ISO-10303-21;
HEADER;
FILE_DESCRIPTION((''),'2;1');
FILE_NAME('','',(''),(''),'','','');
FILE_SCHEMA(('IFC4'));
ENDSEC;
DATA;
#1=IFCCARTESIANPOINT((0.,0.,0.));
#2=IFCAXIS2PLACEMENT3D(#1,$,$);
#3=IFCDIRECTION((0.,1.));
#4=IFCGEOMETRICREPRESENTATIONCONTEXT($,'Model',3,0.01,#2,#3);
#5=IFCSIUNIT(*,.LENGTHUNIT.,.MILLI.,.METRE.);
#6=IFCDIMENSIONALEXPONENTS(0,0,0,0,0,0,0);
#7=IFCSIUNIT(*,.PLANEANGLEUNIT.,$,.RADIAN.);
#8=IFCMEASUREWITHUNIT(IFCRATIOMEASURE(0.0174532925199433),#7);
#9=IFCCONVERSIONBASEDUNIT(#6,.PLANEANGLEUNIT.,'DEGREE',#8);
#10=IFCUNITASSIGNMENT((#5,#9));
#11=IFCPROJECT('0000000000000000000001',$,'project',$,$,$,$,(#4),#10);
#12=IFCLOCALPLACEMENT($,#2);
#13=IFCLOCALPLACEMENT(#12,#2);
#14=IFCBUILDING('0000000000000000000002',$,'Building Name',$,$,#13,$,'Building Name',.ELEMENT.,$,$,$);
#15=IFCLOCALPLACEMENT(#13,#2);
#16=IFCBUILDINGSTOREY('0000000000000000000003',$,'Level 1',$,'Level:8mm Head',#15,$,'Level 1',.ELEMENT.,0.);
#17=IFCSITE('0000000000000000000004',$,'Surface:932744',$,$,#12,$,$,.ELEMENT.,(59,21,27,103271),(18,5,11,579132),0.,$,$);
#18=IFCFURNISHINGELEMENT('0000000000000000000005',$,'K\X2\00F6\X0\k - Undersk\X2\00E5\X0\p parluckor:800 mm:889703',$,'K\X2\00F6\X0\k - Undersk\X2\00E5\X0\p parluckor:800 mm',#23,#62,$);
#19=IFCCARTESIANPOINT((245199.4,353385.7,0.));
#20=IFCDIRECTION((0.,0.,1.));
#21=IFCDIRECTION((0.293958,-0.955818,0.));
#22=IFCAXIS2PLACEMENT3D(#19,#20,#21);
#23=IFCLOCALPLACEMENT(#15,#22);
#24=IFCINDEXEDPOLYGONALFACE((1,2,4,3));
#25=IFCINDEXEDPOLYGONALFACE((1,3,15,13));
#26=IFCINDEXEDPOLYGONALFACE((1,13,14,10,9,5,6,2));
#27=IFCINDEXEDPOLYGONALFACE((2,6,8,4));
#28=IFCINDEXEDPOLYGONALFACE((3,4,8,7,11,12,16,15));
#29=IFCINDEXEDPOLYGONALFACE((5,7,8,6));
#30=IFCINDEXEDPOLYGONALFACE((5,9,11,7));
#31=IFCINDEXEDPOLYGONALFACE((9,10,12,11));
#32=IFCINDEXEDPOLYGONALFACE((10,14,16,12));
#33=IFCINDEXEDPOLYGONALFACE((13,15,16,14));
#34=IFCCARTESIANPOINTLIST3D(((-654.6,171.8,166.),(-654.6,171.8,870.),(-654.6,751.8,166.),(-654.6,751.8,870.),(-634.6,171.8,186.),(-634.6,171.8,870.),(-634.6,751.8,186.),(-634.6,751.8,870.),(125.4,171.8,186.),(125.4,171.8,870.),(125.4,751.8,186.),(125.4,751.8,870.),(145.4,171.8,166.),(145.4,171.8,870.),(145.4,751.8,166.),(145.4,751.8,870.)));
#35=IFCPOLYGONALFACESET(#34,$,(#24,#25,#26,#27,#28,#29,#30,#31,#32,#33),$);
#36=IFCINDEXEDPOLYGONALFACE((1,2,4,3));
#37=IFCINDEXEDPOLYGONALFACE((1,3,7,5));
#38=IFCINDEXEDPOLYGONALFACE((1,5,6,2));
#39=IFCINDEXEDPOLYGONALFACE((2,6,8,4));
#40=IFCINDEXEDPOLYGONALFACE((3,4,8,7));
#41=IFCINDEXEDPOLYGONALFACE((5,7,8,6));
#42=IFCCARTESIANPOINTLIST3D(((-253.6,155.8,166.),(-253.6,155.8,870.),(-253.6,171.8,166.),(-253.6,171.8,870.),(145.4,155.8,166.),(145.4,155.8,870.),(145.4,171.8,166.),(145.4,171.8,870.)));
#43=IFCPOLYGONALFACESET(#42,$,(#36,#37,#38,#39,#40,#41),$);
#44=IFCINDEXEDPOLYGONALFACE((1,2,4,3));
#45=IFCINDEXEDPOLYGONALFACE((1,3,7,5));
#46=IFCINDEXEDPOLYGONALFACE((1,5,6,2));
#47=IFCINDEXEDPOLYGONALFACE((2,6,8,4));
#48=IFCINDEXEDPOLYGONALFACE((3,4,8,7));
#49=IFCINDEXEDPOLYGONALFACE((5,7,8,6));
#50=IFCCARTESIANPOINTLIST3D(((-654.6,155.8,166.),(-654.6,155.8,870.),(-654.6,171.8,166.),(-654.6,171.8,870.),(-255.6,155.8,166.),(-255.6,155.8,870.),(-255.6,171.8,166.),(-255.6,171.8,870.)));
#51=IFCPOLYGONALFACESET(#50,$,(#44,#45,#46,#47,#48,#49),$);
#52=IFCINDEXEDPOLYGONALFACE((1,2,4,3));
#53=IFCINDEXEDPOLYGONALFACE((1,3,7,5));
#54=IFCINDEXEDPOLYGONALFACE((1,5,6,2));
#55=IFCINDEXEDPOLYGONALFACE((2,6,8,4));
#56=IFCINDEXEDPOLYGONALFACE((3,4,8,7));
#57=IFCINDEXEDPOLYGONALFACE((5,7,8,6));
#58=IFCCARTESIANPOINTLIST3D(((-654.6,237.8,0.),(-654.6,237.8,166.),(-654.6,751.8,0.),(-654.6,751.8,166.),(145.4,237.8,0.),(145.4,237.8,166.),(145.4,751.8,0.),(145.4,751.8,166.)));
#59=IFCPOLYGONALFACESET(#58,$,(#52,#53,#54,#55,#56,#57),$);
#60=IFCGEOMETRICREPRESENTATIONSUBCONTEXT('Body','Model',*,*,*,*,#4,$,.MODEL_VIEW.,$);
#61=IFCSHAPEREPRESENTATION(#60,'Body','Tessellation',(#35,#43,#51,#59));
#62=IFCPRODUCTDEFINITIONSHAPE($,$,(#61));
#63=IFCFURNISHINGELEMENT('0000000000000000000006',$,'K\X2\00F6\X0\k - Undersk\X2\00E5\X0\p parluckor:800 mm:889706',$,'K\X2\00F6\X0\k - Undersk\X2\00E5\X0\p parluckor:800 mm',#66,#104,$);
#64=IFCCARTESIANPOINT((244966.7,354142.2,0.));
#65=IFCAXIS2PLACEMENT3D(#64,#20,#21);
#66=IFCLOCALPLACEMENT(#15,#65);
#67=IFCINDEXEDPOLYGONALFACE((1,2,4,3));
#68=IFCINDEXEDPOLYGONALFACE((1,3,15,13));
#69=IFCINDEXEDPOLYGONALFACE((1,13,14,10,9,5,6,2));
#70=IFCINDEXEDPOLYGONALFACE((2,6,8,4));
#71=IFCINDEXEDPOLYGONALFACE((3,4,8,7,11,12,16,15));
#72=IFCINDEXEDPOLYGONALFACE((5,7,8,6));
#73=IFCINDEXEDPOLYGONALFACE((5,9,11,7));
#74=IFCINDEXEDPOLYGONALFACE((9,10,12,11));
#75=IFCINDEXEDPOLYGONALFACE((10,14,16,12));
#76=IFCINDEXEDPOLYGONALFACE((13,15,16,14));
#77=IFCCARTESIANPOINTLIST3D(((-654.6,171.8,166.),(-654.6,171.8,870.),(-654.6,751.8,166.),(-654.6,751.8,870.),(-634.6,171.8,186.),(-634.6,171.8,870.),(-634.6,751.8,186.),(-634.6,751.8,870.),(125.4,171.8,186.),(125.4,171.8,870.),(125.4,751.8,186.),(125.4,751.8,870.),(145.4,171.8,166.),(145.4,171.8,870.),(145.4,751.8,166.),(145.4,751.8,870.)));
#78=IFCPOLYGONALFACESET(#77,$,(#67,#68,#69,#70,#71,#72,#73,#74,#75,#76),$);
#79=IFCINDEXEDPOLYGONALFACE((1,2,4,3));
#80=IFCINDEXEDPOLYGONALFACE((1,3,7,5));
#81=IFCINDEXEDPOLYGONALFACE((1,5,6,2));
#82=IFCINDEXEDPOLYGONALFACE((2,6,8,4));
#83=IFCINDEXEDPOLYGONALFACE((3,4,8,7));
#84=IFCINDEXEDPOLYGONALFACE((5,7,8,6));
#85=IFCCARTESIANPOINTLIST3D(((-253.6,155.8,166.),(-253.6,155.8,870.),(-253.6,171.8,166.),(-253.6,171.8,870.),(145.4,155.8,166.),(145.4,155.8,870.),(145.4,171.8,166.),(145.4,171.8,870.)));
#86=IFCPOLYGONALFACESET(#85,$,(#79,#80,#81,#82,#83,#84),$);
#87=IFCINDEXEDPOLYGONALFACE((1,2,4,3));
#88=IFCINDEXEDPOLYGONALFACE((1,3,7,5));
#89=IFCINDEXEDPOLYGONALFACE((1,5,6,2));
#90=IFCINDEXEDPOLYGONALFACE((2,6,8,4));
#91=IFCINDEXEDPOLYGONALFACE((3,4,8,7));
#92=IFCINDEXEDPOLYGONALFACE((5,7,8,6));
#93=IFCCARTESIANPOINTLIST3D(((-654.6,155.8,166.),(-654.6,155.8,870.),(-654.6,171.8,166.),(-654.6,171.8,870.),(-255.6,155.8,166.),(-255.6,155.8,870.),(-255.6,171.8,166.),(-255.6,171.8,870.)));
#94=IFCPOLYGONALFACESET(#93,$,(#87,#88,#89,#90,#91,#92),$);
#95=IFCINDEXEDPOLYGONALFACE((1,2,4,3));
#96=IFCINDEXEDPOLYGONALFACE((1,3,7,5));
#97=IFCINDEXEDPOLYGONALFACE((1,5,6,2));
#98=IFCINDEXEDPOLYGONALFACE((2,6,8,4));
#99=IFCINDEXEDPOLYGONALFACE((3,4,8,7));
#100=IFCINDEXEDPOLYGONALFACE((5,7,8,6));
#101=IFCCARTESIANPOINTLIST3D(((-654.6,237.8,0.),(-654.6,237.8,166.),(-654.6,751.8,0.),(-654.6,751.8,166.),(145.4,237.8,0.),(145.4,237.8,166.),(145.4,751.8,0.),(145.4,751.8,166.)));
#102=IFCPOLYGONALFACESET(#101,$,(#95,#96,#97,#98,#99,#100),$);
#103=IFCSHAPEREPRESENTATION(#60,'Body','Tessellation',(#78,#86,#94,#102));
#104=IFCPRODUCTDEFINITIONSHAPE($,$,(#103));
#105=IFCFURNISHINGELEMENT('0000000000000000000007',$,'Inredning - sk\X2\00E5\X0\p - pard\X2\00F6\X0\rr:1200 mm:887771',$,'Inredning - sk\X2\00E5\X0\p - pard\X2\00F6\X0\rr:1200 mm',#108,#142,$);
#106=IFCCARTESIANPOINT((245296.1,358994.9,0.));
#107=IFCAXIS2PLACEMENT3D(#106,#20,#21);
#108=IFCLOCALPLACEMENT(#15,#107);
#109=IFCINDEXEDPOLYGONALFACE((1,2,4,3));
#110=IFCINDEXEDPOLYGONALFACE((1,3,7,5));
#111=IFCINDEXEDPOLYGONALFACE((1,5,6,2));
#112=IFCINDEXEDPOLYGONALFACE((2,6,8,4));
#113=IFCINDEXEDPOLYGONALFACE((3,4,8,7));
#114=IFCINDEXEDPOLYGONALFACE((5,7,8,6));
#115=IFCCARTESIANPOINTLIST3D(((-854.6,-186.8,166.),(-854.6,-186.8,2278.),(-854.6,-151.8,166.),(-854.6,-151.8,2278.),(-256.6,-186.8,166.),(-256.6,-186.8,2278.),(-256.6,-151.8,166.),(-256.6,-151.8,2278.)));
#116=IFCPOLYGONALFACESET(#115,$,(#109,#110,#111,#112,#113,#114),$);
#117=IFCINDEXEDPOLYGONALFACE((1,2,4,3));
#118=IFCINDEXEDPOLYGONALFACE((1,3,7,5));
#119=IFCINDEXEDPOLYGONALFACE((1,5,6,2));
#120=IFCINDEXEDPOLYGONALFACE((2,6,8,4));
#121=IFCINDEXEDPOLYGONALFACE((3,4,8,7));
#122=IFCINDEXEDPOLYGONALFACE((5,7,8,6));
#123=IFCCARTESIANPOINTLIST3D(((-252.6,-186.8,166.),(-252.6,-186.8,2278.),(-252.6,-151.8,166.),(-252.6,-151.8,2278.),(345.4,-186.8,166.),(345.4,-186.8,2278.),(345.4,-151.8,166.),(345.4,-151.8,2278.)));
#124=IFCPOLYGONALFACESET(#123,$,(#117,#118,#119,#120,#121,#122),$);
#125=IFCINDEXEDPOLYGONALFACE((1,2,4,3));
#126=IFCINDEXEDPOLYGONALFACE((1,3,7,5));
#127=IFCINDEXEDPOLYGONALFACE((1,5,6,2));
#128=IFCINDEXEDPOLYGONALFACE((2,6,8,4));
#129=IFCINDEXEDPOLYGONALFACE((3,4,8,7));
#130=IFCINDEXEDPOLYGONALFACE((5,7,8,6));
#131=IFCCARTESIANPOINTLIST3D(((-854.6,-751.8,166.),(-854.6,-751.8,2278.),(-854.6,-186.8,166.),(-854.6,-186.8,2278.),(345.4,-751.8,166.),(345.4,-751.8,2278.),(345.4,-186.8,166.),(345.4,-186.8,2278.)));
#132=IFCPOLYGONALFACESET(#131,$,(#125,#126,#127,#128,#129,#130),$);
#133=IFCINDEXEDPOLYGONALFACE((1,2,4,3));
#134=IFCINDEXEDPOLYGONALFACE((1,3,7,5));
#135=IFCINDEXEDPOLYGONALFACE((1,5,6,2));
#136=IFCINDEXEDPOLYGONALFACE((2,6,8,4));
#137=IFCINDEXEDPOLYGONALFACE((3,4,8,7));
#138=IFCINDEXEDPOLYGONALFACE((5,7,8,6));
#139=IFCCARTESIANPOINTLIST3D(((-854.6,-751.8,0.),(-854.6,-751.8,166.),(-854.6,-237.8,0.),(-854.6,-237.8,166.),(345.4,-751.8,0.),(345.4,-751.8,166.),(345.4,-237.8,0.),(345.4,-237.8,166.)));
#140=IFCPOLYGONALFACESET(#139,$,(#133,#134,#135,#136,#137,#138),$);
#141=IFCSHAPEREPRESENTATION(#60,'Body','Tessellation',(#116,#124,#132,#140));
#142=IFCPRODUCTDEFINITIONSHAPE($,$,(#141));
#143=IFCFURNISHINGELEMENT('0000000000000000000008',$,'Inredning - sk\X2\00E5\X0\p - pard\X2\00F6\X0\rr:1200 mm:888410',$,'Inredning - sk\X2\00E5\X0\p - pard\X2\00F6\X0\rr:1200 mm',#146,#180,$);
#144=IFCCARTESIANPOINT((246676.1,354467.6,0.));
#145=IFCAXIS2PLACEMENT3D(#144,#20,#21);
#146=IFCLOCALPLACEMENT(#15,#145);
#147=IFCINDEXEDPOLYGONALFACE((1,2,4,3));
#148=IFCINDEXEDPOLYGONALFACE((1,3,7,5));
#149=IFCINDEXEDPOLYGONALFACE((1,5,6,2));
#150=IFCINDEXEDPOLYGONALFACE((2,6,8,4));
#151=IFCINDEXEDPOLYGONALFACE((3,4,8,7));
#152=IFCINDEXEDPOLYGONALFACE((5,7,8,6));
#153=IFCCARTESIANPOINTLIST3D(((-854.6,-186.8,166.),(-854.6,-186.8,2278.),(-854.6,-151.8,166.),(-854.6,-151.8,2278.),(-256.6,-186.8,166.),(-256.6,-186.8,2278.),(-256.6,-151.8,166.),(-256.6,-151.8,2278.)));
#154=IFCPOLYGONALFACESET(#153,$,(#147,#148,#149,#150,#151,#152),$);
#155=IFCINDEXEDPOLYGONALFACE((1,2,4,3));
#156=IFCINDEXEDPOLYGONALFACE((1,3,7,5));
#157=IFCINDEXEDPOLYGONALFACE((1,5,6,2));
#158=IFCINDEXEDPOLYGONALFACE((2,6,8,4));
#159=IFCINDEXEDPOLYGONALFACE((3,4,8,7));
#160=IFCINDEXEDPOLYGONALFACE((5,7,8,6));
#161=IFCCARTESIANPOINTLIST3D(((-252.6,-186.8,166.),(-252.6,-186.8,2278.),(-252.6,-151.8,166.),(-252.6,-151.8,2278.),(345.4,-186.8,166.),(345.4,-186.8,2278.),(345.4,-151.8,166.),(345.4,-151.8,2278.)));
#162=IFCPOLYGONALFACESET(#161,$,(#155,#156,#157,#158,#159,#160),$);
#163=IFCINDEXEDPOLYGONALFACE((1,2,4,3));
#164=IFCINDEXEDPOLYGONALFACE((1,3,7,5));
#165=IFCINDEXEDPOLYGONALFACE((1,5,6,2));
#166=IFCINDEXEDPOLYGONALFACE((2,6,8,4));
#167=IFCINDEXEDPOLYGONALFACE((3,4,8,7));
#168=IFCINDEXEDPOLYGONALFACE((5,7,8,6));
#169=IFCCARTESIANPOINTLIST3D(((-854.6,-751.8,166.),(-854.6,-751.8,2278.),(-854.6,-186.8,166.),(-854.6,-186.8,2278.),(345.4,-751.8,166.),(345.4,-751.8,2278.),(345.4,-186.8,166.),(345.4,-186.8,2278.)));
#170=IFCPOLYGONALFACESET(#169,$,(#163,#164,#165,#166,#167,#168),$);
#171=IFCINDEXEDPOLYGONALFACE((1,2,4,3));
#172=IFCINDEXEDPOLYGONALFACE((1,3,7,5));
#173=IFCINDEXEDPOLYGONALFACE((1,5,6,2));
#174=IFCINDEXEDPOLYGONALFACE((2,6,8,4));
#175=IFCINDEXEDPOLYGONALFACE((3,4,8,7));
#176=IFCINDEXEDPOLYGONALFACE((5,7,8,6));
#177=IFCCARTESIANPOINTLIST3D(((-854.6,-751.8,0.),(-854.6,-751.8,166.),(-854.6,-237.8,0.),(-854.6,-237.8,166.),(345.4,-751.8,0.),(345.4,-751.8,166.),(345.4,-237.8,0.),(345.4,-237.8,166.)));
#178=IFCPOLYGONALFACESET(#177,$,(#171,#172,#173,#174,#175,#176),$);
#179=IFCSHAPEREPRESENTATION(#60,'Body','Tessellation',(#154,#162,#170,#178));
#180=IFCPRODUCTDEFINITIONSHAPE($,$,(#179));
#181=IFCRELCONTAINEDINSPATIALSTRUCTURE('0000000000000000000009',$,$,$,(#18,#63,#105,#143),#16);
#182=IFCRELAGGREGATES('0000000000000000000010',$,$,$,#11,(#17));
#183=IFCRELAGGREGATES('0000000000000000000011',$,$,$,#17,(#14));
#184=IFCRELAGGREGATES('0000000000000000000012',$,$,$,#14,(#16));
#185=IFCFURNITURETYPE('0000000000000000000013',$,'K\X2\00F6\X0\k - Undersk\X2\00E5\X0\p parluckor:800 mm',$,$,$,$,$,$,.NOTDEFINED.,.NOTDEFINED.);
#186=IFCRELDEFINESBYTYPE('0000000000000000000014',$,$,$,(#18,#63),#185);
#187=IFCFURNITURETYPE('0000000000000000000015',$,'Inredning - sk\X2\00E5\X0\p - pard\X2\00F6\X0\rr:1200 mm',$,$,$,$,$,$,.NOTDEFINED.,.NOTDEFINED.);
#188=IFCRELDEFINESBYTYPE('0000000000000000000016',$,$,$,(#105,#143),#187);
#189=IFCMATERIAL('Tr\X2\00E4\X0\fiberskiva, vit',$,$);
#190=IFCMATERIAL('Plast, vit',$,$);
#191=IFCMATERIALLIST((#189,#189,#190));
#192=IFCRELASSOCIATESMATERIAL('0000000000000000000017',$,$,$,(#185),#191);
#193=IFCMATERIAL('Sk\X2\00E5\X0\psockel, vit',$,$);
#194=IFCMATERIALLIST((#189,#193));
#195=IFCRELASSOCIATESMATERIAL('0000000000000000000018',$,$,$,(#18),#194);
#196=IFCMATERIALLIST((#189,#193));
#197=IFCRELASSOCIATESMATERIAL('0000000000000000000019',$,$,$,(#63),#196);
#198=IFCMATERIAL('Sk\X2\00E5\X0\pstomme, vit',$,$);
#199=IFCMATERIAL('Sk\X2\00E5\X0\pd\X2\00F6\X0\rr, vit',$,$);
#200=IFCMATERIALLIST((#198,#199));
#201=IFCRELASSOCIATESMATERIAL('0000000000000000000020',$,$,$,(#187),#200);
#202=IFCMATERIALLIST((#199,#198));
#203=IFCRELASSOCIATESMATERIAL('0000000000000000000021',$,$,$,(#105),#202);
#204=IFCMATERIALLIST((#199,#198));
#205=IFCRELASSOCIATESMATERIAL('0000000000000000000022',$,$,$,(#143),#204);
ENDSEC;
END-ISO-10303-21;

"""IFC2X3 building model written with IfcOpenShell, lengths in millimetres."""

from ifc_helpers import new_model, entity, si_unit, converted_unit, direction, frame, frame_2d, origin, origin_2d_with_axis, place, context, subcontext, project, spatial, polyline, rectangle, outline, extrude, source, transform, mapped, material, material_list, type_object, type_shapes, element, save


model = new_model("IFC2X3")

# Units and contexts
model_context = context("Model", 3, precision=0.01, world=origin(), true_north=direction((0.0, 1.0)))
body_context = subcontext(model_context, "Body", "Model", "MODEL_VIEW")
ifc_project = project(units=[si_unit("LENGTHUNIT", "METRE", prefix="MILLI"), converted_unit("PLANEANGLEUNIT", "DEGREE", entity("IfcRatioMeasure", 0.0174532925199433), si_unit("PLANEANGLEUNIT", "RADIAN"), dimensions=[0, 0, 0, 0, 0, 0, 0])], contexts=[model_context])

# Site, building, storey
site_placement = place(None, origin())
site = spatial("IfcSite", under=ifc_project, at=site_placement, Name="Surface:932744", CompositionType="ELEMENT", RefLatitude=(59, 21, 27, 103271), RefLongitude=(18, 5, 11, 579132), RefElevation=0.0)
building_placement = place(site_placement, origin())
building = spatial("IfcBuilding", under=site, at=building_placement, Name="Building Name", LongName="Building Name", CompositionType="ELEMENT")
storey_placement = place(building_placement, origin())
storey = spatial("IfcBuildingStorey", under=building, at=storey_placement, Name="Level 1", ObjectType="Level:8mm Head", LongName="Level 1", CompositionType="ELEMENT", Elevation=0.0)

# Furnishing elements
ifc_material_1 = material(Name="Träfiberskiva, vit")
ifc_material_2 = material(Name="Skåpsockel, vit")
ifc_material_3 = material(Name="Plast, vit")
ifc_material_list_1 = material_list([ifc_material_1, ifc_material_1, ifc_material_3])
furniture_type_1 = type_object("IfcFurnitureType", Name="Kök - Underskåp parluckor:800 mm", material=ifc_material_list_1)
shared_shape_1 = source(origin(), body_context, "Body", "SweptSolid", [
    extrude(outline(polyline([(-400.0, -347.0), (-380.0, -347.0), (-380.0, 337.0), (380.0, 337.0), (380.0, -347.0), (400.0, -347.0), (400.0, 357.0), (-400.0, 357.0), (-400.0, -347.0)])), frame((-254.6, 171.8, 523.0), z_axis=(0.0, 1.0, 0.0), x_axis=(1.0, 0.0, 0.0)), (0.0, 0.0, 1.0), 580.0),
    extrude(rectangle(XDim=16.0, YDim=399.0, at=frame_2d((0.0, 0.0), x_axis=(1.0, 0.0))), frame((-54.1, 163.8, 166.0), z_axis=(0.0, 0.0, 1.0), x_axis=(0.0, 1.0, 0.0)), (0.0, 0.0, 1.0), 704.0),
    extrude(rectangle(XDim=16.0, YDim=399.0, at=frame_2d((0.0, 0.0), x_axis=(1.0, 0.0))), frame((-455.1, 163.8, 166.0), z_axis=(0.0, 0.0, 1.0), x_axis=(0.0, 1.0, 0.0)), (0.0, 0.0, 1.0), 704.0),
    extrude(rectangle(XDim=800.0, YDim=514.0, at=origin_2d_with_axis()), frame((-254.6, 494.8, 0.0), z_axis=(0.0, 0.0, 1.0), x_axis=(-1.0, 0.0, 0.0)), (0.0, 0.0, 1.0), 166.0),
])
type_shapes(furniture_type_1, [shared_shape_1])
ifc_material_list_2 = material_list([ifc_material_1, ifc_material_2])
furnishing_1_placement = place(storey_placement, frame((245199.4, 353385.7, 0.0), z_axis=(0.0, 0.0, 1.0), x_axis=(0.293958, -0.955818, 0.0)))
element("IfcFurnishingElement", 1, at=furnishing_1_placement, inside=storey, type_object=furniture_type_1, material=ifc_material_list_2, Name="Kök - Underskåp parluckor:800 mm:889703", ObjectType="Kök - Underskåp parluckor:800 mm", context=body_context, shape_type="MappedRepresentation", body=[
    mapped(shared_shape_1, transform((0.0, 0.0, 0.0), scale=1.0)),
])
ifc_material_list_3 = material_list([ifc_material_1, ifc_material_2])
furnishing_2_placement = place(storey_placement, frame((244966.7, 354142.2, 0.0), z_axis=(0.0, 0.0, 1.0), x_axis=(0.293958, -0.955818, 0.0)))
element("IfcFurnishingElement", 2, at=furnishing_2_placement, inside=storey, type_object=furniture_type_1, material=ifc_material_list_3, Name="Kök - Underskåp parluckor:800 mm:889706", ObjectType="Kök - Underskåp parluckor:800 mm", context=body_context, shape_type="MappedRepresentation", body=[
    mapped(shared_shape_1, transform((0.0, 0.0, 0.0), scale=1.0)),
])
ifc_material_4 = material(Name="Skåpdörr, vit")
ifc_material_5 = material(Name="Skåpstomme, vit")
ifc_material_list_4 = material_list([ifc_material_4, ifc_material_5])
ifc_material_list_5 = material_list([ifc_material_5, ifc_material_4])
furniture_type_2 = type_object("IfcFurnitureType", Name="Inredning - skåp - pardörr:1200 mm", material=ifc_material_list_5)
shared_shape_2 = source(origin(), body_context, "Body", "SweptSolid", [
    extrude(rectangle(XDim=598.0, YDim=35.0, at=origin_2d_with_axis()), frame((-555.6, -169.3, 166.0)), (0.0, 0.0, 1.0), 2112.0),
    extrude(rectangle(XDim=598.0, YDim=35.0, at=frame_2d((0.0, 0.0), x_axis=(1.0, 0.0))), frame((46.4, -169.3, 166.0)), (0.0, 0.0, 1.0), 2112.0),
    extrude(rectangle(XDim=565.0, YDim=1200.0, at=origin_2d_with_axis()), frame((-254.6, -469.3, 166.0), z_axis=(0.0, 0.0, 1.0), x_axis=(0.0, 1.0, 0.0)), (0.0, 0.0, 1.0), 2112.0),
    extrude(rectangle(XDim=514.0, YDim=1200.0, at=origin_2d_with_axis()), frame((-254.6, -494.8, 0.0), z_axis=(0.0, 0.0, 1.0), x_axis=(0.0, 1.0, 0.0)), (0.0, 0.0, 1.0), 166.0),
])
type_shapes(furniture_type_2, [shared_shape_2])
furnishing_3_placement = place(storey_placement, frame((245296.1, 358994.9, 0.0), z_axis=(0.0, 0.0, 1.0), x_axis=(0.293958, -0.955818, 0.0)))
element("IfcFurnishingElement", 3, at=furnishing_3_placement, inside=storey, type_object=furniture_type_2, material=ifc_material_list_4, Name="Inredning - skåp - pardörr:1200 mm:887771", ObjectType="Inredning - skåp - pardörr:1200 mm", context=body_context, shape_type="MappedRepresentation", body=[
    mapped(shared_shape_2, transform((0.0, 0.0, 0.0), scale=1.0)),
])
ifc_material_list_6 = material_list([ifc_material_4, ifc_material_5])
furnishing_4_placement = place(storey_placement, frame((246676.1, 354467.6, 0.0), z_axis=(0.0, 0.0, 1.0), x_axis=(0.293958, -0.955818, 0.0)))
element("IfcFurnishingElement", 4, at=furnishing_4_placement, inside=storey, type_object=furniture_type_2, material=ifc_material_list_6, Name="Inredning - skåp - pardörr:1200 mm:888410", ObjectType="Inredning - skåp - pardörr:1200 mm", context=body_context, shape_type="MappedRepresentation", body=[
    mapped(shared_shape_2, transform((0.0, 0.0, 0.0), scale=1.0)),
])

save(model, "model.ifc")
